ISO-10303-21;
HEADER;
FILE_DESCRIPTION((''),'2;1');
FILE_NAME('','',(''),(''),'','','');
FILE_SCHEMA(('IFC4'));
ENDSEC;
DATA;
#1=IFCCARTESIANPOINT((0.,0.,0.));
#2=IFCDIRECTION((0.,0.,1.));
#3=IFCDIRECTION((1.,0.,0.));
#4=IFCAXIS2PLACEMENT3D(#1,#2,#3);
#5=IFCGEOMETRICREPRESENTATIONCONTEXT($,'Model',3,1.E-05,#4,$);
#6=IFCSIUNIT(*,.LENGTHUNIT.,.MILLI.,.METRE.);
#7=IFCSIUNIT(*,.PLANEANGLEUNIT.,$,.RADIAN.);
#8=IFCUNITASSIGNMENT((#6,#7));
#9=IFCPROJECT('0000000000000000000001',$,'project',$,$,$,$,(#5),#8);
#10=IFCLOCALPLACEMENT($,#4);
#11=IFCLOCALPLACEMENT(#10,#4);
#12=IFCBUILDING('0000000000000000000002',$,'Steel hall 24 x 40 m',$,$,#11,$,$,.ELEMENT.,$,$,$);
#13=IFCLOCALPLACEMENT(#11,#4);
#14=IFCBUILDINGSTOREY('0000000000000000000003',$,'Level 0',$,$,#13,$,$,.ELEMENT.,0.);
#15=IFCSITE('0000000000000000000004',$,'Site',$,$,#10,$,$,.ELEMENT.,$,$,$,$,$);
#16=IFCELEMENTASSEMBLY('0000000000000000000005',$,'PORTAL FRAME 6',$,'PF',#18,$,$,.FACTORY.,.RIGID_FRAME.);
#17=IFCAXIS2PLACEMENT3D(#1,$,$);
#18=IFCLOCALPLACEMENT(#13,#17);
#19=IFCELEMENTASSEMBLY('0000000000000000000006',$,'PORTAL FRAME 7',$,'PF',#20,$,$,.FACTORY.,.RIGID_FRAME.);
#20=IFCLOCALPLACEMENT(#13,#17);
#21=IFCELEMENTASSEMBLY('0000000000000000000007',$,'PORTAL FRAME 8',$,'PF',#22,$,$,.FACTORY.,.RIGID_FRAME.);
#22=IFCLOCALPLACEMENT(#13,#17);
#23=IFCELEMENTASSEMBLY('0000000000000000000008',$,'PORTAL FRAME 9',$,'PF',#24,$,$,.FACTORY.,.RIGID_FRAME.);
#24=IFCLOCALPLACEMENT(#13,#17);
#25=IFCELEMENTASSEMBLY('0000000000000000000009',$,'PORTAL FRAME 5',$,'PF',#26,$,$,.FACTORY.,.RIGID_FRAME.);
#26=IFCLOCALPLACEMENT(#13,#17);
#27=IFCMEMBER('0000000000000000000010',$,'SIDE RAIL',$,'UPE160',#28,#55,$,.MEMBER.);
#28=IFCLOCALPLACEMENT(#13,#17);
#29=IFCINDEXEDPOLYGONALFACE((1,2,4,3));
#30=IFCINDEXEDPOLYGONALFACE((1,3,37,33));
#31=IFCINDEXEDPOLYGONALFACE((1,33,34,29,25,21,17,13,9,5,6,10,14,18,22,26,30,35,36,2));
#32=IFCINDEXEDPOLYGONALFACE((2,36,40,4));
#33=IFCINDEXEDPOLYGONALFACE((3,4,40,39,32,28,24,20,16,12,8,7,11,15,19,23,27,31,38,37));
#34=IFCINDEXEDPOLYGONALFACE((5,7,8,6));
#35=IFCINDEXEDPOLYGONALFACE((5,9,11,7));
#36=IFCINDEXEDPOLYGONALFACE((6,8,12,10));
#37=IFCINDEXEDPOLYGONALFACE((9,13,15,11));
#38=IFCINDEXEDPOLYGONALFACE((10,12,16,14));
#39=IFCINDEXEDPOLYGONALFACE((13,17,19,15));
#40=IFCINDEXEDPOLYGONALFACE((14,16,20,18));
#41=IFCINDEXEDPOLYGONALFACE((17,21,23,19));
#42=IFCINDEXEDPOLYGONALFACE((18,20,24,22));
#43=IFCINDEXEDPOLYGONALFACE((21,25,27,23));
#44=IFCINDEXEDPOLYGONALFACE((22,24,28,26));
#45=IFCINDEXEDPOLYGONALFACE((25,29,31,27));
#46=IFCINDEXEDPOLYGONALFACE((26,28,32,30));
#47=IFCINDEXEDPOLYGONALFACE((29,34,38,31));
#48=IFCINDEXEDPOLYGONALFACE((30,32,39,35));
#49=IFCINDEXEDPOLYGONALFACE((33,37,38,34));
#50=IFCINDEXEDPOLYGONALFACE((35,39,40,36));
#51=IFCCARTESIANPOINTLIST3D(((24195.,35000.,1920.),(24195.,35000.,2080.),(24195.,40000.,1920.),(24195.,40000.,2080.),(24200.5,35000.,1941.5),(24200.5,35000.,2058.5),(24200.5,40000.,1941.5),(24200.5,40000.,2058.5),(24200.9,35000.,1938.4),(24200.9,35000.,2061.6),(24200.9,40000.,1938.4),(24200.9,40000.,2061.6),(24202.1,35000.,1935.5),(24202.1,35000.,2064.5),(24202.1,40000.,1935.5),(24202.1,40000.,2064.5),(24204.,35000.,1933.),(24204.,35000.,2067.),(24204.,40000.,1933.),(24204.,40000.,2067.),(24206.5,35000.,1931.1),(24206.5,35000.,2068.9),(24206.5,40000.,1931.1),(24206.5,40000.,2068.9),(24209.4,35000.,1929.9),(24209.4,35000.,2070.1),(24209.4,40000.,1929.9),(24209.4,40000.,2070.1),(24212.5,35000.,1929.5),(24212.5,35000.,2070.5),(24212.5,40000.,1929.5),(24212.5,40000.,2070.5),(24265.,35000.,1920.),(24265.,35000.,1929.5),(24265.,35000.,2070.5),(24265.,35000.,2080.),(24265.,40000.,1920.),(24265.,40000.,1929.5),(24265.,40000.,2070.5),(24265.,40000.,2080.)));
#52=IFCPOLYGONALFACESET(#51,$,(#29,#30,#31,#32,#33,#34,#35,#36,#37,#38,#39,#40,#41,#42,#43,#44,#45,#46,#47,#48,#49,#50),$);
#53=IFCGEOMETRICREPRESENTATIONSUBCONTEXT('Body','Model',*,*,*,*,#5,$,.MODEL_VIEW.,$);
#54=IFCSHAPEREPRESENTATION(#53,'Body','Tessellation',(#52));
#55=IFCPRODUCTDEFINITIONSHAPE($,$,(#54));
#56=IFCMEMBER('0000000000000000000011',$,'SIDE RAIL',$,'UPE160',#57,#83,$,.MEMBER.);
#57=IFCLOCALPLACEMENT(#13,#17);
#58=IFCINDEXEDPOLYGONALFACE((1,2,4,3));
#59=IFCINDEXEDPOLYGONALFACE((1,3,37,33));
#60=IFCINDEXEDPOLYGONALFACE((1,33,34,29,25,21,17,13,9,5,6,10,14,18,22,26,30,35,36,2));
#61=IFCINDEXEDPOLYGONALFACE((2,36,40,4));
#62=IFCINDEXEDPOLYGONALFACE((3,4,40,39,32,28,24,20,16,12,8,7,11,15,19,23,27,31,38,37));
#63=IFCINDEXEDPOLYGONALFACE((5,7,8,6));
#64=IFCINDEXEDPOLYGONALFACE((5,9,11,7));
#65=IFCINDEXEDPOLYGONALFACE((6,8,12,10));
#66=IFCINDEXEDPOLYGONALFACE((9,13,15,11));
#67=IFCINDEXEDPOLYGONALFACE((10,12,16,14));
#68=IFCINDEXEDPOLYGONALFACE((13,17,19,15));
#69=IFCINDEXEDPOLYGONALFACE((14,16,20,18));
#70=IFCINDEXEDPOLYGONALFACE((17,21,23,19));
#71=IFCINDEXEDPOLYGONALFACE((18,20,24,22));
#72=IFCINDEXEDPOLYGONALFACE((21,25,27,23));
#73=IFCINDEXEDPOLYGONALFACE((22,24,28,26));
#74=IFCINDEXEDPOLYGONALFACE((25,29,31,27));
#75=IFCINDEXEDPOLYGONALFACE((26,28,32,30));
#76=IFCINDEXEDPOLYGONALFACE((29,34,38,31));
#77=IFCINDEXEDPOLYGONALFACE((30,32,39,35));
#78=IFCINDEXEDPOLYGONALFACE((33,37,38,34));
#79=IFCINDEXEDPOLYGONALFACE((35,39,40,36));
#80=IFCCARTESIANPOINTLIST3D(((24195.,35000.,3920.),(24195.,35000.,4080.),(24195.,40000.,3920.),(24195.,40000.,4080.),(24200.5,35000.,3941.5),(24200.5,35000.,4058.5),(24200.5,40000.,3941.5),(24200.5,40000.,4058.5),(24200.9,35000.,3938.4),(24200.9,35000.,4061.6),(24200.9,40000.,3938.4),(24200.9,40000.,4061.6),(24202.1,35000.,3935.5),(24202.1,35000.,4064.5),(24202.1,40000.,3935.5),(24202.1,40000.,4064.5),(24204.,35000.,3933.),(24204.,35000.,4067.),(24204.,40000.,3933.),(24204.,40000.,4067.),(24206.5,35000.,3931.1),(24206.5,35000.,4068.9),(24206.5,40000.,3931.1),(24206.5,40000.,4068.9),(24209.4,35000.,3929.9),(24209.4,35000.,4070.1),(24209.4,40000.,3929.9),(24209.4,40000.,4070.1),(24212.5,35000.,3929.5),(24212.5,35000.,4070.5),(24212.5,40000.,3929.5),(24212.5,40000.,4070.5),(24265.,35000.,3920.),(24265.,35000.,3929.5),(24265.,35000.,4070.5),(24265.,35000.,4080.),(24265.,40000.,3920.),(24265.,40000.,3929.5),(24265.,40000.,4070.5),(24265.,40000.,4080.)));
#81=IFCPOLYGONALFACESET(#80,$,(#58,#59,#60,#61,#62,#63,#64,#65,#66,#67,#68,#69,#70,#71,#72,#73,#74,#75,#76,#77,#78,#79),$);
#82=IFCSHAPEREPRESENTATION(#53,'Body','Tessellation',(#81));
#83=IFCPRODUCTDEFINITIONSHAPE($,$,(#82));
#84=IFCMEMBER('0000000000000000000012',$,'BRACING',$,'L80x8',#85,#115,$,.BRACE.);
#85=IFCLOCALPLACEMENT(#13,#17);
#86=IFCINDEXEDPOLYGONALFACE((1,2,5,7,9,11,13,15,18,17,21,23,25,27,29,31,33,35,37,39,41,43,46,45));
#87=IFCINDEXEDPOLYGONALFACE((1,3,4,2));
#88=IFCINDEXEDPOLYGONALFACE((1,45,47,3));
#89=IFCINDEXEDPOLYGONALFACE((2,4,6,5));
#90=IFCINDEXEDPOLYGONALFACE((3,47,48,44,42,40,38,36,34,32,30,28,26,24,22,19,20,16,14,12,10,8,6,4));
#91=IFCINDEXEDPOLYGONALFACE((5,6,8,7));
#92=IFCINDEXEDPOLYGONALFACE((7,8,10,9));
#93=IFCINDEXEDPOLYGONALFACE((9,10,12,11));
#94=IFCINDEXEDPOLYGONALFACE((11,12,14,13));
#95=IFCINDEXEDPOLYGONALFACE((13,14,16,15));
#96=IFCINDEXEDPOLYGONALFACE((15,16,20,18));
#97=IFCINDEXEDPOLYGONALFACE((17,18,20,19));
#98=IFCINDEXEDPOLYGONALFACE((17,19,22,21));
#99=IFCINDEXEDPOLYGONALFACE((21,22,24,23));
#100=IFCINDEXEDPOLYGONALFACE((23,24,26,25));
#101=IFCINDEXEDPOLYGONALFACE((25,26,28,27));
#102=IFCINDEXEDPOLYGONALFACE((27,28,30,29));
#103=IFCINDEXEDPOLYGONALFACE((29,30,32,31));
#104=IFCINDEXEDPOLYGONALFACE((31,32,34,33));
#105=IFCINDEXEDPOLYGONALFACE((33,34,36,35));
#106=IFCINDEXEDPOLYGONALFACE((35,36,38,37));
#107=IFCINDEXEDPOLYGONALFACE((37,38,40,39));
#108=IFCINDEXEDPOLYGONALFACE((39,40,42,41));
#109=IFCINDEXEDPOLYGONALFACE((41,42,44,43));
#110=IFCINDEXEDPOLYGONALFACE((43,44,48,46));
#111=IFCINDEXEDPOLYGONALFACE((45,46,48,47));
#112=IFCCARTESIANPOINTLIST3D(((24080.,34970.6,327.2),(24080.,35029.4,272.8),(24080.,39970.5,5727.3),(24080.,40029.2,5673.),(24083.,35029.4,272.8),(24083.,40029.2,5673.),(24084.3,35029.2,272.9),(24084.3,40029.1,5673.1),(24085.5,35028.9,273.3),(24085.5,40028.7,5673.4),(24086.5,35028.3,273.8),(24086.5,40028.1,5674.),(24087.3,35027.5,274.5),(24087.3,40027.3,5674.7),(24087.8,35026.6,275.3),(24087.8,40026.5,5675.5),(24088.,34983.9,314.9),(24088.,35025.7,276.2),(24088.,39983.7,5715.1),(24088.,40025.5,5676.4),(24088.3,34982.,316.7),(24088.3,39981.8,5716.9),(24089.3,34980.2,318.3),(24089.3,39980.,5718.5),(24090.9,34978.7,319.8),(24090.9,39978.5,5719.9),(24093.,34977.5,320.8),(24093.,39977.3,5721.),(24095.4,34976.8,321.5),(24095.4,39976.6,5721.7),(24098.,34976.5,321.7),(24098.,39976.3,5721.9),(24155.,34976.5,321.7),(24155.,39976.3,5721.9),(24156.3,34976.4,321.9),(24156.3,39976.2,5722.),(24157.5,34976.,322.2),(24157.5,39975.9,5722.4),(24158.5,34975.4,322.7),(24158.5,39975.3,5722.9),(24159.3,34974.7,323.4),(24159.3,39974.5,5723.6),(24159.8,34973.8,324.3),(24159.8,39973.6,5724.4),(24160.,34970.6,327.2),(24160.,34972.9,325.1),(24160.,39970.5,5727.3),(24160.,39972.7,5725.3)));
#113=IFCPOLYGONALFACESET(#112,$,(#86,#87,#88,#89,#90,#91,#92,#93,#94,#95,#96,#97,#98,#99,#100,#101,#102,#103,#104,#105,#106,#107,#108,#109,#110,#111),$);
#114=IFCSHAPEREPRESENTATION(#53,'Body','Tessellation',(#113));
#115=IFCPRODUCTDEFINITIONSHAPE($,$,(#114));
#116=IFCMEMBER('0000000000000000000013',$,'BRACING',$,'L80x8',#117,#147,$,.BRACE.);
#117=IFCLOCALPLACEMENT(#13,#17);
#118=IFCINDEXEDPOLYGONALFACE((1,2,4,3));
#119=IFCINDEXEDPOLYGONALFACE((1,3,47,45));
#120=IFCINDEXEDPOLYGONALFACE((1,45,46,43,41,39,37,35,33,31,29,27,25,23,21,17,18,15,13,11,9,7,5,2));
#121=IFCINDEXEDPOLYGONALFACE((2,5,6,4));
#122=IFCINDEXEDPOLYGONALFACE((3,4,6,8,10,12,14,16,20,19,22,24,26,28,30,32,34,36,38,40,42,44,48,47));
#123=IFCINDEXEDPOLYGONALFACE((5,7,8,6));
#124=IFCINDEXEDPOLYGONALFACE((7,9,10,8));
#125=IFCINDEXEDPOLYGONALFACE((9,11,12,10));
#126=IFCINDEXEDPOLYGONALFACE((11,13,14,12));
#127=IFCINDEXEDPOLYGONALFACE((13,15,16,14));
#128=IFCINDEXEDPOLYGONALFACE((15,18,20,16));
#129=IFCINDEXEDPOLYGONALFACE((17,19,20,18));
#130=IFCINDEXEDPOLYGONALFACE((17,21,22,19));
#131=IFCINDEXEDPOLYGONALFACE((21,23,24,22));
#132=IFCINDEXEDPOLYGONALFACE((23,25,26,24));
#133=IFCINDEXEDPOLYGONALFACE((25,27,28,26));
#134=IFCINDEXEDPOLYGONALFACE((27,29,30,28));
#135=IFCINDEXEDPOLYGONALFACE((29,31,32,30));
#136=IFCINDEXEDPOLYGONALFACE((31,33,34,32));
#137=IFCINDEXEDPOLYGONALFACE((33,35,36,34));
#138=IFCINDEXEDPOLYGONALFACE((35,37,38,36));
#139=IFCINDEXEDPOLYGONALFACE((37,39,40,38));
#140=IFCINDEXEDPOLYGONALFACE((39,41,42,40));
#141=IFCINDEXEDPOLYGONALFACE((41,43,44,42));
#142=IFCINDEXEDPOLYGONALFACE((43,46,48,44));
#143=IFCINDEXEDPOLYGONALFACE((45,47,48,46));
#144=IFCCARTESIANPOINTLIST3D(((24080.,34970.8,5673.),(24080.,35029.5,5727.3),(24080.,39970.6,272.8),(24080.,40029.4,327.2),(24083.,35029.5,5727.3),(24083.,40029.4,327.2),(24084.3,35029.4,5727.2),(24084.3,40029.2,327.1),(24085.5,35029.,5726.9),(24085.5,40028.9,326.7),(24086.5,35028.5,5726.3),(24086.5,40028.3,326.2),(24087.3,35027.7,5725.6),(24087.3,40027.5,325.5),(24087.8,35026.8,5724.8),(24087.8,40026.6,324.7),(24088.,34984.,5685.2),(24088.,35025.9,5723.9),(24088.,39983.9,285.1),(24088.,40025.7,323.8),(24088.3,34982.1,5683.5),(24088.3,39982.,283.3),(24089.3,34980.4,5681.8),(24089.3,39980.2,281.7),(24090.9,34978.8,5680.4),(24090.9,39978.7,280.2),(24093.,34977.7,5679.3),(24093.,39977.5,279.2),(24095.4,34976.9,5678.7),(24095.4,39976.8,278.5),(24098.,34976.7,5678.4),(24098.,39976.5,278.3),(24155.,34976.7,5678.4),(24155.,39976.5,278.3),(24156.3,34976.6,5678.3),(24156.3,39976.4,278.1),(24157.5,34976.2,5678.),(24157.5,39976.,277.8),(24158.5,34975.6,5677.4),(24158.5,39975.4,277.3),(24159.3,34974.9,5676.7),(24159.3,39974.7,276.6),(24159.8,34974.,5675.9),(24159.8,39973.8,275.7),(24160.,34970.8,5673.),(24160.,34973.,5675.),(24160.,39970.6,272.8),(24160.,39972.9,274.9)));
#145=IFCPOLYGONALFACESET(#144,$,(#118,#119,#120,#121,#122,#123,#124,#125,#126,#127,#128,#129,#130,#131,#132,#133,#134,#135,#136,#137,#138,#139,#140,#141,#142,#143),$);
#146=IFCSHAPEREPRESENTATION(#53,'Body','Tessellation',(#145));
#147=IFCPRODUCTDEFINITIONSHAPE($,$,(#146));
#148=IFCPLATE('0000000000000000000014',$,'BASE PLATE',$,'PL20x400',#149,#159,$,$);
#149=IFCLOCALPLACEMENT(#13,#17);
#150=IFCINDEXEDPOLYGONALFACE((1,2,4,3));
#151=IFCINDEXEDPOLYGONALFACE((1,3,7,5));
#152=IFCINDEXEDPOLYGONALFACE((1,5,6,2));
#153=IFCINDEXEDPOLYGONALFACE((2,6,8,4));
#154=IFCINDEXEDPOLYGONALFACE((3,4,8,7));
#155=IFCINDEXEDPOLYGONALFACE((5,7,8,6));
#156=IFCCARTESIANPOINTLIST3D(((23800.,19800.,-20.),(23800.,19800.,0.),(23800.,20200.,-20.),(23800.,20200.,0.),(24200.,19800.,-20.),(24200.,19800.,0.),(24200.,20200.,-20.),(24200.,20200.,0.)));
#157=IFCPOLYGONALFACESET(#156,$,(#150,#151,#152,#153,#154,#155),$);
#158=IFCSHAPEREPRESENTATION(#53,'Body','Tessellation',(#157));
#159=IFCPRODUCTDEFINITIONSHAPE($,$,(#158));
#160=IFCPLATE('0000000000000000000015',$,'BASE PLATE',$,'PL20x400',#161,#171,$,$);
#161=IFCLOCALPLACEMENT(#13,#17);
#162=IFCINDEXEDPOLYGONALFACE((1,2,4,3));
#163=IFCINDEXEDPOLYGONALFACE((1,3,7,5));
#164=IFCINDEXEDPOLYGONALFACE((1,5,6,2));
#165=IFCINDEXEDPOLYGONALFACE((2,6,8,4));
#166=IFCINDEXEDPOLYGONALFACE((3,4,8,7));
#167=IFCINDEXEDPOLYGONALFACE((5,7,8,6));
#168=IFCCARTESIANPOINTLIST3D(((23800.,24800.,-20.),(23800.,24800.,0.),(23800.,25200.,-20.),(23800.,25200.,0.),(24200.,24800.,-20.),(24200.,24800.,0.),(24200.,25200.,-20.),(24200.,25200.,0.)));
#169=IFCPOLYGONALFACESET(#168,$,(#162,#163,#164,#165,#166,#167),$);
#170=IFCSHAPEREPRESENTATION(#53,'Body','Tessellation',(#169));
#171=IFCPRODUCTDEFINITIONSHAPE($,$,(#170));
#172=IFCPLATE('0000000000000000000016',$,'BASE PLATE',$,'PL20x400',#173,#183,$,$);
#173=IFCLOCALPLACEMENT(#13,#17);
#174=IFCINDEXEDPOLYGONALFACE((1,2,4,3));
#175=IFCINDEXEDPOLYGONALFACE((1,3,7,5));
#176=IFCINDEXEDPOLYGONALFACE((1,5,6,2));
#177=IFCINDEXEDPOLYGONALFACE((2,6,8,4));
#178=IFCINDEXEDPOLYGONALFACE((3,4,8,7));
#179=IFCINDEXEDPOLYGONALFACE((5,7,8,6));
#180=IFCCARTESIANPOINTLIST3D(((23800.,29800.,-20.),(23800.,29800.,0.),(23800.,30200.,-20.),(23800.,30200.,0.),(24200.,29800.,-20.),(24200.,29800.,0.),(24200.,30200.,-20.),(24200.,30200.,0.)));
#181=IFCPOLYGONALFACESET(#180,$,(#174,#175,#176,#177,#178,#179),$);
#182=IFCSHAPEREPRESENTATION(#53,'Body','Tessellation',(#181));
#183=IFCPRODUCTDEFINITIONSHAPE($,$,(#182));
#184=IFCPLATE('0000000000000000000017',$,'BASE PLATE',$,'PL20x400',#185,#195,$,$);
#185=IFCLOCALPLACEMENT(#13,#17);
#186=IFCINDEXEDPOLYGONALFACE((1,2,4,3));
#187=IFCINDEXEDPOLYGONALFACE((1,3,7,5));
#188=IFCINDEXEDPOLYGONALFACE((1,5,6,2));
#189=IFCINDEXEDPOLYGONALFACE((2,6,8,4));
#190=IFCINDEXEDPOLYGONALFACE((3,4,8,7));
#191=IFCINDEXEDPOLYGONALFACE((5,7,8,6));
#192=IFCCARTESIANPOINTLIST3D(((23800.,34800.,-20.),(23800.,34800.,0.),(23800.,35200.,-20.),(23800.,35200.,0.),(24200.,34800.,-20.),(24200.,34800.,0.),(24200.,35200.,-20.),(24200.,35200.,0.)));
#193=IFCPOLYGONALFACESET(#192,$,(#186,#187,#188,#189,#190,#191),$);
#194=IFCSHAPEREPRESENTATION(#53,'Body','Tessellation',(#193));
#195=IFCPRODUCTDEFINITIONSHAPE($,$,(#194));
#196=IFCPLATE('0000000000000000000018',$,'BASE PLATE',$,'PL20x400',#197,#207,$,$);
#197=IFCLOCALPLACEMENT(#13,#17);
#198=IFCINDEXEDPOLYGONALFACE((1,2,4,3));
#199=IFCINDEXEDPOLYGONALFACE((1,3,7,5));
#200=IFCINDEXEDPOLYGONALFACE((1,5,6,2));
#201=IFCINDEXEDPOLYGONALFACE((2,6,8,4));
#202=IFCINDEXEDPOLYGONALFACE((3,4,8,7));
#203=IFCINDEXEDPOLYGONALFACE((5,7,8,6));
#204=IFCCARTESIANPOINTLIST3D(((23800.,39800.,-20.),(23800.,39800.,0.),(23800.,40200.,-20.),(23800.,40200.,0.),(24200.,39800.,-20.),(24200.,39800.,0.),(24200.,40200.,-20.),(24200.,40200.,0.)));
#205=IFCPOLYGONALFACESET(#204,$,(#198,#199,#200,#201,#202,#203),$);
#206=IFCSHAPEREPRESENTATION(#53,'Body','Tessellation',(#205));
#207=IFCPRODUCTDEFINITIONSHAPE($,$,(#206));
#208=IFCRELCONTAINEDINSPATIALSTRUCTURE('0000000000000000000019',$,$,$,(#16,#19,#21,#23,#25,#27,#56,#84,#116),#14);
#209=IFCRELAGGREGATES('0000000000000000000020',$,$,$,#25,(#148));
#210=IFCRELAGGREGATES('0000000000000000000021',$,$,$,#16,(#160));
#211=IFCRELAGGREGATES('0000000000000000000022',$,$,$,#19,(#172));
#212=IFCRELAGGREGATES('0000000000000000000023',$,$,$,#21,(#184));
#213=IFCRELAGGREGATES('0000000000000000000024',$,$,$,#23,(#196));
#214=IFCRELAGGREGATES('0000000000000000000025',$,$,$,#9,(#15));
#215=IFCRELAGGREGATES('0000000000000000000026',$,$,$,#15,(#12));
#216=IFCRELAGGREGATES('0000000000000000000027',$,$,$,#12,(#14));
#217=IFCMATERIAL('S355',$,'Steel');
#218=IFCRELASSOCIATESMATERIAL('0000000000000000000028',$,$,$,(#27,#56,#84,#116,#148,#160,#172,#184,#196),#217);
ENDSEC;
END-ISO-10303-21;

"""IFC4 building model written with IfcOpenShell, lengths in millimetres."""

from ifc_helpers import new_model, si_unit, frame, origin_with_axes, place, context, subcontext, project, spatial, rectangle, l_section, u_section, extrude, material, element, aggregate, save


model = new_model("IFC4")

# Units and contexts
model_context = context("Model", 3, precision=1e-05, world=origin_with_axes())
body_context = subcontext(model_context, "Body", "Model", "MODEL_VIEW")
ifc_project = project(units=[si_unit("LENGTHUNIT", "METRE", prefix="MILLI"), si_unit("PLANEANGLEUNIT", "RADIAN")], contexts=[model_context])

# Site, building, storey
site_placement = place(None, origin_with_axes())
site = spatial("IfcSite", under=ifc_project, at=site_placement, Name="Site", CompositionType="ELEMENT")
building_placement = place(site_placement, origin_with_axes())
building = spatial("IfcBuilding", under=site, at=building_placement, Name="Steel hall 24 x 40 m", CompositionType="ELEMENT")
storey_placement = place(building_placement, origin_with_axes())
storey = spatial("IfcBuildingStorey", under=building, at=storey_placement, Name="Level 0", CompositionType="ELEMENT", Elevation=0.0)

# Element assemblies
assembly_1_placement = place(storey_placement, frame((0.0, 25000.0, 0.0), z_axis=(0.0, 0.0, 1.0), x_axis=(1.0, 0.0, 0.0)))
assembly_1 = element("IfcElementAssembly", 1, at=assembly_1_placement, inside=storey, Name="PORTAL FRAME 6", ObjectType="PF", AssemblyPlace="FACTORY", PredefinedType="RIGID_FRAME")
ifc_material = material(Name="S355", Category="Steel")
assembly_2_placement = place(storey_placement, frame((0.0, 30000.0, 0.0), z_axis=(0.0, 0.0, 1.0), x_axis=(1.0, 0.0, 0.0)))
assembly_2 = element("IfcElementAssembly", 2, at=assembly_2_placement, inside=storey, Name="PORTAL FRAME 7", ObjectType="PF", AssemblyPlace="FACTORY", PredefinedType="RIGID_FRAME")
assembly_3_placement = place(storey_placement, frame((0.0, 35000.0, 0.0), z_axis=(0.0, 0.0, 1.0), x_axis=(1.0, 0.0, 0.0)))
assembly_3 = element("IfcElementAssembly", 3, at=assembly_3_placement, inside=storey, Name="PORTAL FRAME 8", ObjectType="PF", AssemblyPlace="FACTORY", PredefinedType="RIGID_FRAME")
assembly_4_placement = place(storey_placement, frame((0.0, 40000.0, 0.0), z_axis=(0.0, 0.0, 1.0), x_axis=(1.0, 0.0, 0.0)))
assembly_4 = element("IfcElementAssembly", 4, at=assembly_4_placement, inside=storey, Name="PORTAL FRAME 9", ObjectType="PF", AssemblyPlace="FACTORY", PredefinedType="RIGID_FRAME")

# Element assembly
assembly_5_placement = place(storey_placement, frame((0.0, 20000.0, 0.0), z_axis=(0.0, 0.0, 1.0), x_axis=(1.0, 0.0, 0.0)))
assembly_5 = element("IfcElementAssembly", 5, at=assembly_5_placement, inside=storey, Name="PORTAL FRAME 5", ObjectType="PF", AssemblyPlace="FACTORY", PredefinedType="RIGID_FRAME")

# Members
for number, where, z_axis, x_axis, name in (
    (6, (24230.0, 35000.0, 2000.0), (0.0, 1.0, 0.0), (1.0, 0.0, 0.0), "SIDE RAIL"),
    (7, (24230.0, 35000.0, 4000.0), (0.0, 1.0, 0.0), (1.0, 0.0, 0.0), "SIDE RAIL"),
):
    element("IfcMember", number, at=place(storey_placement, frame(where, z_axis=z_axis, x_axis=x_axis)), inside=storey, material=ifc_material, Name=name, ObjectType="UPE160", PredefinedType="MEMBER", context=body_context, shape_type="SweptSolid", body=[
        extrude(u_section(Depth=160.0, FlangeWidth=70.0, WebThickness=5.5, FlangeThickness=9.5, FilletRadius=12.0), origin_with_axes(), (0.0, 0.0, 1.0), 5000.0),
    ])
for number, where, z_axis, x_axis, name in (
    (8, (24120.0, 35000.0, 300.0), (0.0, 0.6794, 0.7338), (1.0, 0.0, 0.0), "BRACING"),
    (9, (24120.0, 40000.0, 300.0), (0.0, -0.6794, 0.7338), (1.0, 0.0, 0.0), "BRACING"),
):
    element("IfcMember", number, at=place(storey_placement, frame(where, z_axis=z_axis, x_axis=x_axis)), inside=storey, material=ifc_material, Name=name, ObjectType="L80x8", PredefinedType="BRACE", context=body_context, shape_type="SweptSolid", body=[
        extrude(l_section(Depth=80.0, Width=80.0, Thickness=8.0, FilletRadius=10.0, EdgeRadius=5.0), origin_with_axes(), (0.0, 0.0, 1.0), 7359.3),
    ])

# Plates
plate_1_placement = place(storey_placement, frame((24000.0, 20000.0, -20.0), z_axis=(0.0, 0.0, 1.0), x_axis=(1.0, 0.0, 0.0)))
plate_1 = element("IfcPlate", 10, at=plate_1_placement, material=ifc_material, Name="BASE PLATE", ObjectType="PL20x400", context=body_context, shape_type="SweptSolid", body=[
    extrude(rectangle(XDim=400.0, YDim=400.0), origin_with_axes(), (0.0, 0.0, 1.0), 20.0),
])
aggregate(assembly_5, [plate_1])
plate_2_placement = place(storey_placement, frame((24000.0, 25000.0, -20.0), z_axis=(0.0, 0.0, 1.0), x_axis=(1.0, 0.0, 0.0)))
plate_2 = element("IfcPlate", 11, at=plate_2_placement, material=ifc_material, Name="BASE PLATE", ObjectType="PL20x400", context=body_context, shape_type="SweptSolid", body=[
    extrude(rectangle(XDim=400.0, YDim=400.0), origin_with_axes(), (0.0, 0.0, 1.0), 20.0),
])
aggregate(assembly_1, [plate_2])
plate_3_placement = place(storey_placement, frame((24000.0, 30000.0, -20.0), z_axis=(0.0, 0.0, 1.0), x_axis=(1.0, 0.0, 0.0)))
plate_3 = element("IfcPlate", 12, at=plate_3_placement, material=ifc_material, Name="BASE PLATE", ObjectType="PL20x400", context=body_context, shape_type="SweptSolid", body=[
    extrude(rectangle(XDim=400.0, YDim=400.0), origin_with_axes(), (0.0, 0.0, 1.0), 20.0),
])
aggregate(assembly_2, [plate_3])
plate_4_placement = place(storey_placement, frame((24000.0, 35000.0, -20.0), z_axis=(0.0, 0.0, 1.0), x_axis=(1.0, 0.0, 0.0)))
plate_4 = element("IfcPlate", 13, at=plate_4_placement, material=ifc_material, Name="BASE PLATE", ObjectType="PL20x400", context=body_context, shape_type="SweptSolid", body=[
    extrude(rectangle(XDim=400.0, YDim=400.0), origin_with_axes(), (0.0, 0.0, 1.0), 20.0),
])
aggregate(assembly_3, [plate_4])
plate_5_placement = place(storey_placement, frame((24000.0, 40000.0, -20.0), z_axis=(0.0, 0.0, 1.0), x_axis=(1.0, 0.0, 0.0)))
plate_5 = element("IfcPlate", 14, at=plate_5_placement, material=ifc_material, Name="BASE PLATE", ObjectType="PL20x400", context=body_context, shape_type="SweptSolid", body=[
    extrude(rectangle(XDim=400.0, YDim=400.0), origin_with_axes(), (0.0, 0.0, 1.0), 20.0),
])
aggregate(assembly_4, [plate_5])

save(model, "model.ifc")
